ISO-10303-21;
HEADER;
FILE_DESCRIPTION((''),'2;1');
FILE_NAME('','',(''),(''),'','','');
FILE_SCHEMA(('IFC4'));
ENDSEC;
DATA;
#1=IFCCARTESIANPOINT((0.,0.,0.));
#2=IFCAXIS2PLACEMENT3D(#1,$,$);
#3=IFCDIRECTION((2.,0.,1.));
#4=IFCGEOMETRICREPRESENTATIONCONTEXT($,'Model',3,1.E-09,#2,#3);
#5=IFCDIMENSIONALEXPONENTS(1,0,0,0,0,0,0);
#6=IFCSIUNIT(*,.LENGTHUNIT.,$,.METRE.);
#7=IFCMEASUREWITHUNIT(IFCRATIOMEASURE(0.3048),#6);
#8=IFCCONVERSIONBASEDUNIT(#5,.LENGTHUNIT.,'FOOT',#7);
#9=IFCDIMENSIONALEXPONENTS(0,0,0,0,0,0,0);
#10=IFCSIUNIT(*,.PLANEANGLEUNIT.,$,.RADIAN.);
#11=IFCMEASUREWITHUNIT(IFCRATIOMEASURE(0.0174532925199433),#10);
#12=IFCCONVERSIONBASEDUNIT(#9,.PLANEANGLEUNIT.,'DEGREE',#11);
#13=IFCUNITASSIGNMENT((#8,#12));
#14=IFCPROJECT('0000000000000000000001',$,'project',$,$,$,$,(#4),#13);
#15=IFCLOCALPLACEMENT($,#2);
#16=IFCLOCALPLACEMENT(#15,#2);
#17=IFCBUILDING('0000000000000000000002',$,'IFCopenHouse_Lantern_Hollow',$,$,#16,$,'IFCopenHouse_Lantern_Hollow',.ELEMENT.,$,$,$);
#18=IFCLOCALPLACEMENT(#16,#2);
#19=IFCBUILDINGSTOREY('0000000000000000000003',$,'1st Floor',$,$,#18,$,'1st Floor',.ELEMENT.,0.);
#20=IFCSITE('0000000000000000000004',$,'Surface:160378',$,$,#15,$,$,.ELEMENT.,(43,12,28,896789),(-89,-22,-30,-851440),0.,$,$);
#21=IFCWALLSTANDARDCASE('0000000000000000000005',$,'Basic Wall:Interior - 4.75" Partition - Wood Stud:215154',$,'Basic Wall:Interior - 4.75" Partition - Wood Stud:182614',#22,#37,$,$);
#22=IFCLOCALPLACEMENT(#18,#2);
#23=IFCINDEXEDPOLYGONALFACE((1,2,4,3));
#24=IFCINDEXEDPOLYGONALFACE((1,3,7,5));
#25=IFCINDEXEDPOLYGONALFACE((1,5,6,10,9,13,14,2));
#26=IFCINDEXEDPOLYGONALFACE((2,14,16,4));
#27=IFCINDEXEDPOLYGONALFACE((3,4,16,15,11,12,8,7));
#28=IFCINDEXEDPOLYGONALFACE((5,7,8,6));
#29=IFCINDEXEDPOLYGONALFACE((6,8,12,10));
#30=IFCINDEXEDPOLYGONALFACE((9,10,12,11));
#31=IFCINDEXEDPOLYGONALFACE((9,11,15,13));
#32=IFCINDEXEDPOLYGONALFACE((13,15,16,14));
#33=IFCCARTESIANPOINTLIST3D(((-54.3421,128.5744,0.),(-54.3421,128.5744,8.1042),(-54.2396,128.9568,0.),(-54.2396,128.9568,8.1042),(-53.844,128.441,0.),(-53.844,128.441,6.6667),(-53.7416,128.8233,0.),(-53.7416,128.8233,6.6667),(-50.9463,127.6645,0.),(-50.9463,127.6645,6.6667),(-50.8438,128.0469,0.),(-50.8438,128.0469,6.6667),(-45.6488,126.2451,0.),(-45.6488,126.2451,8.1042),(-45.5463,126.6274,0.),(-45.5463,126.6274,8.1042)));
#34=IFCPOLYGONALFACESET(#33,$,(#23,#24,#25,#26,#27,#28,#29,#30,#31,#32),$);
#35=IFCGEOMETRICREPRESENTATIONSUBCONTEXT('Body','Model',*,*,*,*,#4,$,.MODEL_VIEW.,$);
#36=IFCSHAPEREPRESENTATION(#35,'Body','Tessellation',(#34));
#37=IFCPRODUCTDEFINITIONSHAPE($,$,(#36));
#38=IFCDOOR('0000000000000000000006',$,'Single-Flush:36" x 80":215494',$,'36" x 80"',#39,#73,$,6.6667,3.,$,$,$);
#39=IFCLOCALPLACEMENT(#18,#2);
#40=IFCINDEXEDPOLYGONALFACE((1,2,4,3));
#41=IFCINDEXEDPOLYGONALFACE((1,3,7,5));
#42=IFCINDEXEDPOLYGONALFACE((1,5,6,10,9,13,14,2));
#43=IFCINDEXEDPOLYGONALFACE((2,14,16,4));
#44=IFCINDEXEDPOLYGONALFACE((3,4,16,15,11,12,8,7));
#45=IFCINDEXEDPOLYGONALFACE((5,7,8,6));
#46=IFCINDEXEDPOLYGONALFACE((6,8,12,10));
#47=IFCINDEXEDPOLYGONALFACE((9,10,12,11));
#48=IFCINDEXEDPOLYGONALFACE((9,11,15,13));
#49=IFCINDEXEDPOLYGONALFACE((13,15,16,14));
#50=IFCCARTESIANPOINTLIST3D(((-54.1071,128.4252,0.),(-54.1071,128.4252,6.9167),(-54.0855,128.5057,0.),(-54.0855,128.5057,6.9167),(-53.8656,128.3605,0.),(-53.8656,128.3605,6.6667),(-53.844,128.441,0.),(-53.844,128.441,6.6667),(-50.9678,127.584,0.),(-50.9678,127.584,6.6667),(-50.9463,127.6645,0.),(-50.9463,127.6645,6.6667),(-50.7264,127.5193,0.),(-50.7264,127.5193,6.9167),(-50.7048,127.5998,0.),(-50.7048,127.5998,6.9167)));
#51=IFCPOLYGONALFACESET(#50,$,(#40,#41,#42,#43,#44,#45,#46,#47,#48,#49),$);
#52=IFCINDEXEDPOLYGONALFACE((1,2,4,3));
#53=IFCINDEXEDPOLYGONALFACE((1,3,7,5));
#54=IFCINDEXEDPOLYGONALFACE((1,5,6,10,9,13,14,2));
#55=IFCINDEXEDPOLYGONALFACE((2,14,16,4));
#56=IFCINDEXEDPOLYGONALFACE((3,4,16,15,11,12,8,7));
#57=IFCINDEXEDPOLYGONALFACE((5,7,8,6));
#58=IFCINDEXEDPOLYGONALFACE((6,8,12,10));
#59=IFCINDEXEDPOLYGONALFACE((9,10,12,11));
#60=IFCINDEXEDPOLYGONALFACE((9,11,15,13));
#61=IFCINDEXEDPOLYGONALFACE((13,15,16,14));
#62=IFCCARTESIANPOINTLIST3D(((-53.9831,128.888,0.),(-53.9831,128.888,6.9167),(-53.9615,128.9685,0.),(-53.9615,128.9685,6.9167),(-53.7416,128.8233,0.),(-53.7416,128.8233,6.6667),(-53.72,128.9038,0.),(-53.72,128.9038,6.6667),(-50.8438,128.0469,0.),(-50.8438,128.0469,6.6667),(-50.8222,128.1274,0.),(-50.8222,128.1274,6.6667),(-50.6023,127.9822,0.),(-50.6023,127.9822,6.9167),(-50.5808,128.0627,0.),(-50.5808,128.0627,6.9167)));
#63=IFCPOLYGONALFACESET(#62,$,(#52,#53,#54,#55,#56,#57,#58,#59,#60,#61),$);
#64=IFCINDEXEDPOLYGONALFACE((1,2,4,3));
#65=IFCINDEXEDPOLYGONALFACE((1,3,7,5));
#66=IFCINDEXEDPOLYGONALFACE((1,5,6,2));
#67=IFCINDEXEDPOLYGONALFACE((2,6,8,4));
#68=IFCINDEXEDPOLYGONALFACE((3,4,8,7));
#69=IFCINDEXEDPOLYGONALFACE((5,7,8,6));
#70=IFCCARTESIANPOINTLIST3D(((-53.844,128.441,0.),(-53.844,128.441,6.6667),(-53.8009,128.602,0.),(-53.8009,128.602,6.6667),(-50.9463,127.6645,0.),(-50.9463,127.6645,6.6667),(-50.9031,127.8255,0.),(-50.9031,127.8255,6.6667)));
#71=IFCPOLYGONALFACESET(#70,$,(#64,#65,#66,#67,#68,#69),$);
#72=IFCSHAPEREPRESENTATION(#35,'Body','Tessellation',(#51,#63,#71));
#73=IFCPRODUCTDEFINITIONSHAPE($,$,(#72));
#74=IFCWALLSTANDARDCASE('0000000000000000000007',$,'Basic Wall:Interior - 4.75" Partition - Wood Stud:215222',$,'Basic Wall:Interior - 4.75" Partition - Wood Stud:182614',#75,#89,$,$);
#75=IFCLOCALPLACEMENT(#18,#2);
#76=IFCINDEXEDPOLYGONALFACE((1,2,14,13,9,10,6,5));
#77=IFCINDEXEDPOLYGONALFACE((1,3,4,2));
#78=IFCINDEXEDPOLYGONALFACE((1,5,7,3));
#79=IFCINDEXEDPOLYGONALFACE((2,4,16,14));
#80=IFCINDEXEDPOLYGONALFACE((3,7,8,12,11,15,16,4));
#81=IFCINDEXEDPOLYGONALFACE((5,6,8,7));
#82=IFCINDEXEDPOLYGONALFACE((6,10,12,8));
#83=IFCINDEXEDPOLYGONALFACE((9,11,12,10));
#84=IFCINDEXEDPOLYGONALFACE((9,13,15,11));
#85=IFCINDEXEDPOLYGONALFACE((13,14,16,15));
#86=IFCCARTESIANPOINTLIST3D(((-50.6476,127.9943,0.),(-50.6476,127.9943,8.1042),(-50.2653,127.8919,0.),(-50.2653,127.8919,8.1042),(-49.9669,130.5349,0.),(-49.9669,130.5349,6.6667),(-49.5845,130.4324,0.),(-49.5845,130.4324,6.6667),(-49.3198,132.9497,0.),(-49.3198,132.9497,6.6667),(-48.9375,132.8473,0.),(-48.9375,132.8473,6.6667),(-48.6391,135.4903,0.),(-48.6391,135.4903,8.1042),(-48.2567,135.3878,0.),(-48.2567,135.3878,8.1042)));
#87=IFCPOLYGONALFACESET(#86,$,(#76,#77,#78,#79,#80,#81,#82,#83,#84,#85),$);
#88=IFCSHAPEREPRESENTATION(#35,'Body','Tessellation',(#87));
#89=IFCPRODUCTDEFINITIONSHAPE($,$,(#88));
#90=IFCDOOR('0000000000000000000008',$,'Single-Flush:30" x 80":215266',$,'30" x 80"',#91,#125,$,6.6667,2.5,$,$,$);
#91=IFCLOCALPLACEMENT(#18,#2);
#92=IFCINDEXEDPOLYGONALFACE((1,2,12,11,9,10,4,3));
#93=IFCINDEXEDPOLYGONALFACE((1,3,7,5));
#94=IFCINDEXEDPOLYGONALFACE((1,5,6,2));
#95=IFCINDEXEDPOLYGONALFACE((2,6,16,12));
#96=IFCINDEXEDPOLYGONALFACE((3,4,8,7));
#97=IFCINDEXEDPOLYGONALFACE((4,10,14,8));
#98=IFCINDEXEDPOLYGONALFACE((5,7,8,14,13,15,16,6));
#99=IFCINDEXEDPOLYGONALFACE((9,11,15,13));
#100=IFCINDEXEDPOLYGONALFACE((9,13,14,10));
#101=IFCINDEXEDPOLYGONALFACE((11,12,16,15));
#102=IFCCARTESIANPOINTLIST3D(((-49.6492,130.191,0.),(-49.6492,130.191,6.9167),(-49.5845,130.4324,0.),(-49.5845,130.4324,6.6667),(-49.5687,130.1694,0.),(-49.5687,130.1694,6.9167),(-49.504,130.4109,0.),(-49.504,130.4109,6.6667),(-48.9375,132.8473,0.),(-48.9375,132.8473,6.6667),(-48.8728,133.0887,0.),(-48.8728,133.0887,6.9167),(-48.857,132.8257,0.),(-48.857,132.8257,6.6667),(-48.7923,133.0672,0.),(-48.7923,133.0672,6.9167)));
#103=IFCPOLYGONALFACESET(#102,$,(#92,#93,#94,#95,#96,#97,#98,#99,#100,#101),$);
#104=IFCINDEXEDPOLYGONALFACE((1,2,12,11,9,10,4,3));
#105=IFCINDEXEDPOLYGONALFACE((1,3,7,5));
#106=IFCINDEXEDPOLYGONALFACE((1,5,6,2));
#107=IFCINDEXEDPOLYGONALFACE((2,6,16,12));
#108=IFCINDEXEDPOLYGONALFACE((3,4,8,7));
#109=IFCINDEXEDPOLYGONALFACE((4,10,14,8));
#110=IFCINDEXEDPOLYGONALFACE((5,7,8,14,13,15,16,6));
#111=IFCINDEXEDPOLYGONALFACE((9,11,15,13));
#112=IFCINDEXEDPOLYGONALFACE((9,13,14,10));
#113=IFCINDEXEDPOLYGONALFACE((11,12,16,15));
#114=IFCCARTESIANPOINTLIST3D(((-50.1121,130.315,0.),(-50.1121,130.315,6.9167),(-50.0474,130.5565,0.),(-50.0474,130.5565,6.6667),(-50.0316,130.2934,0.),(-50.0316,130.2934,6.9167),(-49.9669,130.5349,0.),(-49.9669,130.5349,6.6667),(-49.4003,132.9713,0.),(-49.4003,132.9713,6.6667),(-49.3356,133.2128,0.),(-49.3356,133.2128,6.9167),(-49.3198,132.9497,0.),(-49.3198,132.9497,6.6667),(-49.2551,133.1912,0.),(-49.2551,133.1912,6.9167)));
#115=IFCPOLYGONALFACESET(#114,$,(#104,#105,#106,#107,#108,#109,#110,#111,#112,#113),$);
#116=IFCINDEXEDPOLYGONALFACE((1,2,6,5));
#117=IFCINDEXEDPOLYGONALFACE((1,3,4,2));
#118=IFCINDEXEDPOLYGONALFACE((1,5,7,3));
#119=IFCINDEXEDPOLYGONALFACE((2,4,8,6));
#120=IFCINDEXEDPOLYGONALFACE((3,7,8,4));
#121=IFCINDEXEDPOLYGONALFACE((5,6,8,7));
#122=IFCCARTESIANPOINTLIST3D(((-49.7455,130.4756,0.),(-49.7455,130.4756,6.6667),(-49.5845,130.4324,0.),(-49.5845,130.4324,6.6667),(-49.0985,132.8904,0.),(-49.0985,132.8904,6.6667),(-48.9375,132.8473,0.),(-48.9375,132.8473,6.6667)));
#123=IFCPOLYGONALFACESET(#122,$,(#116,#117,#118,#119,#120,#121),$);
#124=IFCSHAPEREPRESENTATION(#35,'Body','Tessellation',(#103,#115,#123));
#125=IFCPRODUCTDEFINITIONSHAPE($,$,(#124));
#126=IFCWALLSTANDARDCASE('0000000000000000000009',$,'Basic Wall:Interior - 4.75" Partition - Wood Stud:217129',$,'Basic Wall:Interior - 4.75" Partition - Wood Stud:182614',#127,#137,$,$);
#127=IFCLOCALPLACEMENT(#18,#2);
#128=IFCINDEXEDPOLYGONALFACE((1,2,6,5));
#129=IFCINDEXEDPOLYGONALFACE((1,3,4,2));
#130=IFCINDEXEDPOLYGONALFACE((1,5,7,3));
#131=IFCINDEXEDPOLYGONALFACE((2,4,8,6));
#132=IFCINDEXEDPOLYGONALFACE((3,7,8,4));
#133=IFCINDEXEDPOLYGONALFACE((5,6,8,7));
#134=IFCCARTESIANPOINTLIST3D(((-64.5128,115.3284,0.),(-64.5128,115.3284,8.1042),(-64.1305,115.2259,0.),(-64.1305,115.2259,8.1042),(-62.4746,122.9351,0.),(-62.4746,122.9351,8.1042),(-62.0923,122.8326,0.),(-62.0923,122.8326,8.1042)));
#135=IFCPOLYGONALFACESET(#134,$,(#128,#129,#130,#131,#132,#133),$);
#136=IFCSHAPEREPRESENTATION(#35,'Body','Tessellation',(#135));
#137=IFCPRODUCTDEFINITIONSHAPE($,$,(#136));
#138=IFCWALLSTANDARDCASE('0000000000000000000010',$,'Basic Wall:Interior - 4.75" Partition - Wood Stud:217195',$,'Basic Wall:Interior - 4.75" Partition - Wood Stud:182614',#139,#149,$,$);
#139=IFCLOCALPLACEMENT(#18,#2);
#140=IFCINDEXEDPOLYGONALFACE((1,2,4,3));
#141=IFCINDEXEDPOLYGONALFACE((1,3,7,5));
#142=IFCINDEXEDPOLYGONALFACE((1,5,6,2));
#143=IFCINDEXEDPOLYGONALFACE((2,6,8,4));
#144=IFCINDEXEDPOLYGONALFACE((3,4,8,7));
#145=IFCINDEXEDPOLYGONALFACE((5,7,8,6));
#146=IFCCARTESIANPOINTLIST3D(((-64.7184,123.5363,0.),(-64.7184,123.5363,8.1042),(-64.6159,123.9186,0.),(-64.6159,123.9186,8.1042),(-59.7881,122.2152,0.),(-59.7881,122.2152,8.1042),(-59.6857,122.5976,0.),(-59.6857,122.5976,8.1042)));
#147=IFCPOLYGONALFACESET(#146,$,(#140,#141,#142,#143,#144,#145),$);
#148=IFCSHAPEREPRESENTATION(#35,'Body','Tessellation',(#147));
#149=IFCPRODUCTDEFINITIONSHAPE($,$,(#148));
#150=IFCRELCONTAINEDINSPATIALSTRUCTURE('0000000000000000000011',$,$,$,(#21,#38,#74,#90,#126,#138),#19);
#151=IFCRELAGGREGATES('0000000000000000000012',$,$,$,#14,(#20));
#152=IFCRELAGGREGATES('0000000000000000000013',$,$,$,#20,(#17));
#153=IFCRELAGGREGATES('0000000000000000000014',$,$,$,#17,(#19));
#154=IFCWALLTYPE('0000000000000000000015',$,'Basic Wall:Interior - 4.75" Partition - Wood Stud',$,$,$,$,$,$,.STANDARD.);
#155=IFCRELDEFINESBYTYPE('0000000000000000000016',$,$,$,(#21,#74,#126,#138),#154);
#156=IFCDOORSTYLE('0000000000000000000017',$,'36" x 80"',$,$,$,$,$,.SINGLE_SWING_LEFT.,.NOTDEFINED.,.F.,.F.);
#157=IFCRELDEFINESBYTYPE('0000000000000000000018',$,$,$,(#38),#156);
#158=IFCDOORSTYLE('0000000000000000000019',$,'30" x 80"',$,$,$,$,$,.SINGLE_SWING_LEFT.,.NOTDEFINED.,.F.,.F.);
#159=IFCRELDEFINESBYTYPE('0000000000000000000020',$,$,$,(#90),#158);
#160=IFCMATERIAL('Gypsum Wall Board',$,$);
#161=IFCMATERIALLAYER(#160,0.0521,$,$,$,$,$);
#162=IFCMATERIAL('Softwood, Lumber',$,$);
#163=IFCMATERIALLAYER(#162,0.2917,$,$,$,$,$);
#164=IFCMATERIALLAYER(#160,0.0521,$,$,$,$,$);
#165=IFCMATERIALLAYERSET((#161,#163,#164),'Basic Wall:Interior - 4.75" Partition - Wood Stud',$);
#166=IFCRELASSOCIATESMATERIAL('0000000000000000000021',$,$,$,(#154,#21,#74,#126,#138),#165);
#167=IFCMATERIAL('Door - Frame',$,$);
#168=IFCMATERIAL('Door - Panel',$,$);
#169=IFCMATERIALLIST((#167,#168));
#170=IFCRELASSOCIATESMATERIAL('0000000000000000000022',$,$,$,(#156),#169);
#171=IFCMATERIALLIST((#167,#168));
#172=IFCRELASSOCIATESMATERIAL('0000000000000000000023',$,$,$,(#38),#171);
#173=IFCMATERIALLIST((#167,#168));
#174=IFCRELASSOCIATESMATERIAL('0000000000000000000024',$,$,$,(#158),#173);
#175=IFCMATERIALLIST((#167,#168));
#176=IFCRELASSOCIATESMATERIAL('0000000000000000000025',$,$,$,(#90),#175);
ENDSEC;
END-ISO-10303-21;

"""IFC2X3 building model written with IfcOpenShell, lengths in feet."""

from ifc_helpers import new_model, entity, si_unit, converted_unit, direction, frame, frame_2d, origin, origin_2d_with_axis, place, context, subcontext, project, spatial, polyline, rectangle, outline, extrude, source, transform, mapped, material, material_list, layer, layer_set, layer_usage, type_object, type_shapes, element, fill, save


model = new_model("IFC2X3")

# Units and contexts
model_context = context("Model", 3, precision=1e-09, world=origin(), true_north=direction((2.0, 0.0, 1.0)))
body_context = subcontext(model_context, "Body", "Model", "MODEL_VIEW")
ifc_project = project(units=[converted_unit("LENGTHUNIT", "FOOT", entity("IfcRatioMeasure", 0.3048), si_unit("LENGTHUNIT", "METRE"), dimensions=[1, 0, 0, 0, 0, 0, 0]), converted_unit("PLANEANGLEUNIT", "DEGREE", entity("IfcRatioMeasure", 0.0174532925199433), si_unit("PLANEANGLEUNIT", "RADIAN"), dimensions=[0, 0, 0, 0, 0, 0, 0])], contexts=[model_context])

# Site, building, storey
site_placement = place(None, origin())
site = spatial("IfcSite", under=ifc_project, at=site_placement, Name="Surface:160378", CompositionType="ELEMENT", RefLatitude=(43, 12, 28, 896789), RefLongitude=(-89, -22, -30, -851440), RefElevation=0.0)
building_placement = place(site_placement, origin())
building = spatial("IfcBuilding", under=site, at=building_placement, Name="IFCopenHouse_Lantern_Hollow", LongName="IFCopenHouse_Lantern_Hollow", CompositionType="ELEMENT")
storey_placement = place(building_placement, origin())
storey = spatial("IfcBuildingStorey", under=building, at=storey_placement, Name="1st Floor", LongName="1st Floor", CompositionType="ELEMENT", Elevation=0.0)

# Shared definitions
ifc_material_1 = material(Name="Softwood, Lumber")
ifc_material_2 = material(Name="Gypsum Wall Board")

# Shared definitions
ifc_layer_1 = layer(ifc_material_2, 0.0521)
ifc_layer_2 = layer(ifc_material_1, 0.2917)
ifc_layer_3 = layer(ifc_material_2, 0.0521)
ifc_layer_set_1 = layer_set([ifc_layer_1, ifc_layer_2, ifc_layer_3], Name="Basic Wall:Interior - 4.75\" Partition - Wood Stud")
wall_type = type_object("IfcWallType", Name="Basic Wall:Interior - 4.75\" Partition - Wood Stud", PredefinedType="STANDARD", material=ifc_layer_set_1)
ifc_material_3 = material(Name="Door - Panel")
ifc_material_4 = material(Name="Door - Frame")

# Walls, openings, doors
ifc_layer_usage_1 = layer_usage(ifc_layer_set_1, "AXIS2", "NEGATIVE", 0.1979)
wall_1_placement = place(storey_placement, frame((-45.5975, 126.4362, 0.0), z_axis=(0.0, 0.0, 1.0), x_axis=(-0.965926, 0.258819, 0.0)))
wall_1 = element("IfcWallStandardCase", 1, at=wall_1_placement, inside=storey, type_object=wall_type, material=ifc_layer_usage_1, Name="Basic Wall:Interior - 4.75\" Partition - Wood Stud:215154", ObjectType="Basic Wall:Interior - 4.75\" Partition - Wood Stud:182614", context=body_context, shape_type="SweptSolid", body=[
    extrude(rectangle(XDim=9.0, YDim=0.3958, at=frame_2d((4.5, 0.0), x_axis=(-1.0, 0.0))), origin(), (0.0, 0.0, 1.0), 8.1042),
])
opening_1_placement = place(wall_1_placement, frame((5.4844, -0.1979, 0.0)))
opening_1 = element("IfcOpeningElement", 2, at=opening_1_placement, cuts=wall_1, ObjectType="Opening", context=body_context, shape_type="SweptSolid", body=[
    extrude(rectangle(XDim=3.0, YDim=6.6667, at=frame_2d((3.3333, 1.5), x_axis=(0.0, -1.0))), frame((0.0, 0.0, 0.0), z_axis=(0.0, 1.0, 0.0), x_axis=(0.0, 0.0, 1.0)), (0.0, 0.0, 1.0), 0.3958),
])
ifc_material_list_1 = material_list([ifc_material_4, ifc_material_3])
ifc_material_list_2 = material_list([ifc_material_4, ifc_material_3])
door_style_1 = type_object("IfcDoorStyle", Name="36\" x 80\"", ConstructionType="NOTDEFINED", OperationType="SINGLE_SWING_LEFT", ParameterTakesPrecedence=False, Sizeable=False, material=ifc_material_list_2)
shared_shape_1 = source(origin(), body_context, "Body", "SweptSolid", [
    extrude(outline(polyline([(-1.75, -3.5208), (1.75, -3.5208), (1.75, 3.3958), (1.5, 3.3958), (1.5, -3.2708), (-1.5, -3.2708), (-1.5, 3.3958), (-1.75, 3.3958), (-1.75, -3.5208)])), frame((1.5, 0.4792, 3.3958), z_axis=(0.0, -1.0, 0.0), x_axis=(-1.0, 0.0, 0.0)), (0.0, 0.0, 1.0), 0.0833),
    extrude(outline(polyline([(-3.5208, -1.75), (3.3958, -1.75), (3.3958, -1.5), (-3.2708, -1.5), (-3.2708, 1.5), (3.3958, 1.5), (3.3958, 1.75), (-3.5208, 1.75), (-3.5208, -1.75)])), frame((1.5, 0.0, 3.3958), z_axis=(0.0, -1.0, 0.0), x_axis=(0.0, 0.0, -1.0)), (0.0, 0.0, 1.0), 0.0833),
    extrude(rectangle(XDim=3.0, YDim=0.1667, at=origin_2d_with_axis()), frame((1.5, 0.3125, 0.0)), (0.0, 0.0, 1.0), 6.6667),
])
type_shapes(door_style_1, [shared_shape_1])
door_1_placement = place(opening_1_placement, origin())
door_1 = element("IfcDoor", 3, at=door_1_placement, inside=storey, type_object=door_style_1, material=ifc_material_list_1, Name="Single-Flush:36\" x 80\":215494", ObjectType="36\" x 80\"", OverallHeight=6.6667, OverallWidth=3.0, context=body_context, shape_type="MappedRepresentation", body=[
    mapped(shared_shape_1, transform((0.0, 0.0, 0.0), scale=1.0)),
])
fill(opening_1, door_1)
ifc_layer_usage_2 = layer_usage(ifc_layer_set_1, "AXIS2", "NEGATIVE", 0.1979)
wall_2_placement = place(storey_placement, frame((-50.4564, 127.9431, 0.0), z_axis=(0.0, 0.0, 1.0), x_axis=(0.258819, 0.965926, 0.0)))
wall_2 = element("IfcWallStandardCase", 4, at=wall_2_placement, inside=storey, type_object=wall_type, material=ifc_layer_usage_2, Name="Basic Wall:Interior - 4.75\" Partition - Wood Stud:215222", ObjectType="Basic Wall:Interior - 4.75\" Partition - Wood Stud:182614", context=body_context, shape_type="SweptSolid", body=[
    extrude(rectangle(XDim=7.7604, YDim=0.3958, at=frame_2d((3.8802, 0.0), x_axis=(-1.0, 0.0))), origin(), (0.0, 0.0, 1.0), 8.1042),
])
opening_2_placement = place(wall_2_placement, frame((5.1302, 0.1979, 0.0)))
opening_2 = element("IfcOpeningElement", 5, at=opening_2_placement, cuts=wall_2, ObjectType="Opening", context=body_context, shape_type="SweptSolid", body=[
    extrude(rectangle(XDim=2.5, YDim=6.6667, at=frame_2d((3.3333, 1.25), x_axis=(0.0, -1.0))), frame((0.0, 0.0, 0.0), z_axis=(0.0, -1.0, 0.0), x_axis=(0.0, 0.0, 1.0)), (0.0, 0.0, 1.0), 0.3958),
])
ifc_material_list_3 = material_list([ifc_material_4, ifc_material_3])
ifc_material_list_4 = material_list([ifc_material_4, ifc_material_3])
door_style_2 = type_object("IfcDoorStyle", Name="30\" x 80\"", ConstructionType="NOTDEFINED", OperationType="SINGLE_SWING_LEFT", ParameterTakesPrecedence=False, Sizeable=False, material=ifc_material_list_4)
shared_shape_2 = source(origin(), body_context, "Body", "SweptSolid", [
    extrude(outline(polyline([(-1.5, -3.5208), (1.5, -3.5208), (1.5, 3.3958), (1.25, 3.3958), (1.25, -3.2708), (-1.25, -3.2708), (-1.25, 3.3958), (-1.5, 3.3958), (-1.5, -3.5208)])), frame((1.25, 0.4792, 3.3958), z_axis=(0.0, -1.0, 0.0), x_axis=(-1.0, 0.0, 0.0)), (0.0, 0.0, 1.0), 0.0833),
    extrude(outline(polyline([(-3.5208, -1.5), (3.3958, -1.5), (3.3958, -1.25), (-3.2708, -1.25), (-3.2708, 1.25), (3.3958, 1.25), (3.3958, 1.5), (-3.5208, 1.5), (-3.5208, -1.5)])), frame((1.25, 0.0, 3.3958), z_axis=(0.0, -1.0, 0.0), x_axis=(0.0, 0.0, -1.0)), (0.0, 0.0, 1.0), 0.0833),
    extrude(rectangle(XDim=2.5, YDim=0.1667, at=origin_2d_with_axis()), frame((1.25, 0.3125, 0.0)), (0.0, 0.0, 1.0), 6.6667),
])
type_shapes(door_style_2, [shared_shape_2])
door_2_placement = place(opening_2_placement, frame((0.0, 0.0, 0.0), z_axis=(0.0, 0.0, 1.0), x_axis=(-1.0, 0.0, 0.0)))
door_2 = element("IfcDoor", 6, at=door_2_placement, inside=storey, type_object=door_style_2, material=ifc_material_list_3, Name="Single-Flush:30\" x 80\":215266", ObjectType="30\" x 80\"", OverallHeight=6.6667, OverallWidth=2.5, context=body_context, shape_type="MappedRepresentation", body=[
    mapped(shared_shape_2, transform((0.0, 0.0, 0.0), scale=1.0)),
])
fill(opening_2, door_2)

# Walls
ifc_layer_usage_3 = layer_usage(ifc_layer_set_1, "AXIS2", "NEGATIVE", 0.1979)
wall_3_placement = place(storey_placement, frame((-64.3216, 115.2772, 0.0), z_axis=(0.0, 0.0, 1.0), x_axis=(0.258819, 0.965926, 0.0)))
element("IfcWallStandardCase", 7, at=wall_3_placement, inside=storey, type_object=wall_type, material=ifc_layer_usage_3, Name="Basic Wall:Interior - 4.75\" Partition - Wood Stud:217129", ObjectType="Basic Wall:Interior - 4.75\" Partition - Wood Stud:182614", context=body_context, shape_type="SweptSolid", body=[
    extrude(rectangle(XDim=7.875, YDim=0.3958, at=frame_2d((3.9375, 0.0), x_axis=(-1.0, 0.0))), origin(), (0.0, 0.0, 1.0), 8.1042),
])
ifc_layer_usage_4 = layer_usage(ifc_layer_set_1, "AXIS2", "NEGATIVE", 0.1979)
wall_4_placement = place(storey_placement, frame((-59.7369, 122.4064, 0.0), z_axis=(0.0, 0.0, 1.0), x_axis=(-0.965926, 0.258819, 0.0)))
element("IfcWallStandardCase", 8, at=wall_4_placement, inside=storey, type_object=wall_type, material=ifc_layer_usage_4, Name="Basic Wall:Interior - 4.75\" Partition - Wood Stud:217195", ObjectType="Basic Wall:Interior - 4.75\" Partition - Wood Stud:182614", context=body_context, shape_type="SweptSolid", body=[
    extrude(rectangle(XDim=5.1042, YDim=0.3958, at=frame_2d((2.5521, 0.0), x_axis=(-1.0, 0.0))), origin(), (0.0, 0.0, 1.0), 8.1042),
])

save(model, "model.ifc")
